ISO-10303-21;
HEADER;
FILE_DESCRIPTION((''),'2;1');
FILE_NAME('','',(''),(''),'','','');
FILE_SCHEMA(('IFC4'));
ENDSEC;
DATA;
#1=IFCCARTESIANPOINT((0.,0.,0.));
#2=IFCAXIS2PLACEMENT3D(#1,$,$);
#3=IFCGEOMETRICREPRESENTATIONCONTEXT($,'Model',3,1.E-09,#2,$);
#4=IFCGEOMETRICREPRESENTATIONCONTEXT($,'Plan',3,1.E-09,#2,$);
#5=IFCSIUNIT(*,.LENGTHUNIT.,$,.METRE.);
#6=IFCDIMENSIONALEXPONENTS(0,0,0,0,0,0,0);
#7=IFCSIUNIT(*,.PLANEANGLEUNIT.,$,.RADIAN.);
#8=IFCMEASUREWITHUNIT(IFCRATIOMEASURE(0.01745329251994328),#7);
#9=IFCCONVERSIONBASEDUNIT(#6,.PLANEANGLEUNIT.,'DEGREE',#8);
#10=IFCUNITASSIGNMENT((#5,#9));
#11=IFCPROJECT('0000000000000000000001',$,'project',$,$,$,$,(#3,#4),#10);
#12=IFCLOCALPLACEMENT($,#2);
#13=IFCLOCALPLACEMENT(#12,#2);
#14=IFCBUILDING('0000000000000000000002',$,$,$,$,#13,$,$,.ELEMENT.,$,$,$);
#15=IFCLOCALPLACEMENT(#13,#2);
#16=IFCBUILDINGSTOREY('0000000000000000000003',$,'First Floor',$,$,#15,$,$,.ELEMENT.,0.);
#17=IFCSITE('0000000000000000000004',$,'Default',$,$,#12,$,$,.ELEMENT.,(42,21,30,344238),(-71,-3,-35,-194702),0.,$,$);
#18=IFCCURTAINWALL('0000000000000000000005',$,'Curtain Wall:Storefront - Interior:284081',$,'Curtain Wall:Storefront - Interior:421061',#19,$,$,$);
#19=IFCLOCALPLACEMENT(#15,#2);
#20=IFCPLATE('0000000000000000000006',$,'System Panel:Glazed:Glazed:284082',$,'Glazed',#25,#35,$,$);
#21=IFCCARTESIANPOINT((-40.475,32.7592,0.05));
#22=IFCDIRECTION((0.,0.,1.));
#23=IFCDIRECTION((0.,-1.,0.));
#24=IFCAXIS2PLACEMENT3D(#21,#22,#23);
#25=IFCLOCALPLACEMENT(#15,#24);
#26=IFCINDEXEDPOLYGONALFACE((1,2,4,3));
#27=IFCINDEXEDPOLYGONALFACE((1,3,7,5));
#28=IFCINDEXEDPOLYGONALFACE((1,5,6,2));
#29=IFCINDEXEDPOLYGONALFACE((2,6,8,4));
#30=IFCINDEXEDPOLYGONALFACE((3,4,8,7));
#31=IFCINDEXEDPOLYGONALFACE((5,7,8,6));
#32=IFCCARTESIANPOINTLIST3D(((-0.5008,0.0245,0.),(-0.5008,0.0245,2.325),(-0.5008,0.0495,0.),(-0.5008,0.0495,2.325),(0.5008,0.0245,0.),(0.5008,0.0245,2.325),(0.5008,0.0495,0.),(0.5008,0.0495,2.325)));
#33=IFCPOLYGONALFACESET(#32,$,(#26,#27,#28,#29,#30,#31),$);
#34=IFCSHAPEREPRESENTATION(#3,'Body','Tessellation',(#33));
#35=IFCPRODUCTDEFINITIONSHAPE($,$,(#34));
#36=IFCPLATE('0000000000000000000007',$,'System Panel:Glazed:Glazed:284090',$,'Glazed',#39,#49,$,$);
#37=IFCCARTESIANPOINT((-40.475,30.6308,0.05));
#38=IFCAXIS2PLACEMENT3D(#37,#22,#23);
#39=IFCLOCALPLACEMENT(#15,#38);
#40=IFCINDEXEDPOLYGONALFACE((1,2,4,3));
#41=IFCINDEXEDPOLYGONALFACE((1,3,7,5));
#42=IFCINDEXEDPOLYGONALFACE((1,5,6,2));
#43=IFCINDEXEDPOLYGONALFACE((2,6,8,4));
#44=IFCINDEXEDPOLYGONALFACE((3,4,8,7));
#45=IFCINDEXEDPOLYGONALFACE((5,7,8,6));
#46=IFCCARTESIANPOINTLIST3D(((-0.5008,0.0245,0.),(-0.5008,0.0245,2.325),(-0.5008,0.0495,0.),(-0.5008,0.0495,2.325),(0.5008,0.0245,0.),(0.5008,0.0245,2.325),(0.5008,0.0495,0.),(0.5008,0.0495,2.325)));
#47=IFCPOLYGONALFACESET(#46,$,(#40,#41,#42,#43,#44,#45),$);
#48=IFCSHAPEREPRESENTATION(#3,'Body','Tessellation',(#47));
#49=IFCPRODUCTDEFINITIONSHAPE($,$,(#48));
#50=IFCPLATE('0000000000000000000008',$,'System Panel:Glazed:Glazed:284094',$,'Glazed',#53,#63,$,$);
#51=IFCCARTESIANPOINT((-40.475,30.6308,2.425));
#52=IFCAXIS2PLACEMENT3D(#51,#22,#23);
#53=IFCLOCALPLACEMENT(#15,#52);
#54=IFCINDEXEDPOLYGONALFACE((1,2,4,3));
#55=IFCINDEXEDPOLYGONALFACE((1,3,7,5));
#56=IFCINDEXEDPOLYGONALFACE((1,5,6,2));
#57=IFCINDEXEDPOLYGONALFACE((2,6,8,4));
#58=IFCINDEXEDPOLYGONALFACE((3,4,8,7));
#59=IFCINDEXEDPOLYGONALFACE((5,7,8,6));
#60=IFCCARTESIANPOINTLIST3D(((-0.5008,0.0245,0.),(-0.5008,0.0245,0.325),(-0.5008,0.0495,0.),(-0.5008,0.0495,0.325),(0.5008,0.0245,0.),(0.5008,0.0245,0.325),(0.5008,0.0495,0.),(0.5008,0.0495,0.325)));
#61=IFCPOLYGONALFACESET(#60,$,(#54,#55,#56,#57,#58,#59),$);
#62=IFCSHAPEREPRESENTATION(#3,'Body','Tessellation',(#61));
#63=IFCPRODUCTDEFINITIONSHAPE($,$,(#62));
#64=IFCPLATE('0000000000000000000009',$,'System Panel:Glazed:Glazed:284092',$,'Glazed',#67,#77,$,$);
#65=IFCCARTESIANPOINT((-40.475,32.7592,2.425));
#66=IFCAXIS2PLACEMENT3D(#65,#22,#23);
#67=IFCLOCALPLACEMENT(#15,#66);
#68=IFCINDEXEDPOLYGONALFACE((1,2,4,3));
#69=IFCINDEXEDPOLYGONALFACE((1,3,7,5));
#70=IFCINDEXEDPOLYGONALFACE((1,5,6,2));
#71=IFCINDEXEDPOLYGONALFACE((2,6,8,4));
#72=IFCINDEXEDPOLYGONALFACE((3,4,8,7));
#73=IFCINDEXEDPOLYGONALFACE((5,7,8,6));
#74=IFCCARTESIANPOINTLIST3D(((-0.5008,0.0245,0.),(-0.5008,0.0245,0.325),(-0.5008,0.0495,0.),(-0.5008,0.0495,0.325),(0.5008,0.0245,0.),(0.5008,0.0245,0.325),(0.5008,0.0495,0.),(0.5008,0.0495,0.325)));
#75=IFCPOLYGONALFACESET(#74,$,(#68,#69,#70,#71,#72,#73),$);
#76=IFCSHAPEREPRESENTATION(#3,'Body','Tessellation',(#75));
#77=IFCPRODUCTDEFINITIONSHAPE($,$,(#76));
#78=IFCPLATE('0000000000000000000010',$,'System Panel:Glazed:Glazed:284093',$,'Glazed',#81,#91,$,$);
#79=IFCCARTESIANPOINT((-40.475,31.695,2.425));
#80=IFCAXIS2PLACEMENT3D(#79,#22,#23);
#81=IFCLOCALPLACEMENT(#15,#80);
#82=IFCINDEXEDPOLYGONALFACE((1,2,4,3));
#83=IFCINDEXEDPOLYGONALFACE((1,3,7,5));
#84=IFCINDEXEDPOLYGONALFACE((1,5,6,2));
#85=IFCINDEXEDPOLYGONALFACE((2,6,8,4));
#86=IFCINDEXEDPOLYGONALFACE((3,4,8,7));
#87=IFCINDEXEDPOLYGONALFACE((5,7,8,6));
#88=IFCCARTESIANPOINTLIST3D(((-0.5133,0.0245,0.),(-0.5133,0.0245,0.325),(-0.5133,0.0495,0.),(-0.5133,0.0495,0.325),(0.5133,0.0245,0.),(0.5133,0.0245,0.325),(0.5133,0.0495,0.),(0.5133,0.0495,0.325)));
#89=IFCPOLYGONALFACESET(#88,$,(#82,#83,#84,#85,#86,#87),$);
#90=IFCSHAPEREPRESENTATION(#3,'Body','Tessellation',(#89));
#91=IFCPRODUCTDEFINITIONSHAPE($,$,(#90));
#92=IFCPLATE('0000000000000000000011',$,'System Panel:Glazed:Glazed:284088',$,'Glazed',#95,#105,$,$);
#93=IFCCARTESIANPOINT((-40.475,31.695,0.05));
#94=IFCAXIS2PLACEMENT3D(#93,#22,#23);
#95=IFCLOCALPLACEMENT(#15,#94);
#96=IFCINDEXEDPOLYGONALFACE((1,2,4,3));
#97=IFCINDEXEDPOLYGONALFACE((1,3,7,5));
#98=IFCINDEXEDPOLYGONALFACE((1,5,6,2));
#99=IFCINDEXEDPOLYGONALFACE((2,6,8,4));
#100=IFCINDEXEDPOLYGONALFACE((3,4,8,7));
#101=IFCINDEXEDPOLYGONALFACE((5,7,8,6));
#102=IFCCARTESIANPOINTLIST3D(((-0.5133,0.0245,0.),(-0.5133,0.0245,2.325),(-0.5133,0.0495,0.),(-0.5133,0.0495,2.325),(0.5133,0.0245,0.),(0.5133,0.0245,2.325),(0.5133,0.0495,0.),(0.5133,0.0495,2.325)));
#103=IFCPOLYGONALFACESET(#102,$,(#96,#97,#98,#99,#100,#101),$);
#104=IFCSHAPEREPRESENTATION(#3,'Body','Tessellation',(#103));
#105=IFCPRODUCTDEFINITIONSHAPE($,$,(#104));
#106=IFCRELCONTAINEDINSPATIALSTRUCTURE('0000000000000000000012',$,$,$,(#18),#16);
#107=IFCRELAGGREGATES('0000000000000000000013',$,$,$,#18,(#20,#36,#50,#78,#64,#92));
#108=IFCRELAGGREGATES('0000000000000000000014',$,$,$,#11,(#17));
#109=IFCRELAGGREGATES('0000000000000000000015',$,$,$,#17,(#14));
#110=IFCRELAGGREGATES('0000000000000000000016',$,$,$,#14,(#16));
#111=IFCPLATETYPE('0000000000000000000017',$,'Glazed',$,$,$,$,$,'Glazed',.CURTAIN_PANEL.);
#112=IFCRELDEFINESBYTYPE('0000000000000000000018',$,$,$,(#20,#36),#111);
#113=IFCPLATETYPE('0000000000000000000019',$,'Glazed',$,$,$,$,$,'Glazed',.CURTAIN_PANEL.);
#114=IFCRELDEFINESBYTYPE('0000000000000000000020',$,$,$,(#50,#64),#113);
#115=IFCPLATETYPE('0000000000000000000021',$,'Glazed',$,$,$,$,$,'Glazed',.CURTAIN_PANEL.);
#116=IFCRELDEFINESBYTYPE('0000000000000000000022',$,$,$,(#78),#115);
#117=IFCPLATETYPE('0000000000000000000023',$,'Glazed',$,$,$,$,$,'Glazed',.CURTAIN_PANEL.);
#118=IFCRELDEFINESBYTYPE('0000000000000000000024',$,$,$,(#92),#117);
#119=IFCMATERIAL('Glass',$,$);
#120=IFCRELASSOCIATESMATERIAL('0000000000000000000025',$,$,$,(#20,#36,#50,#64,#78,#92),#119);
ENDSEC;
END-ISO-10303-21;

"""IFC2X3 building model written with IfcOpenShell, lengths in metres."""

from ifc_helpers import new_model, entity, si_unit, converted_unit, frame, origin, origin_2d_with_axis, place, context, project, spatial, rectangle, extrude, source, transform, mapped, material, type_object, type_shapes, element, aggregate, save


model = new_model("IFC2X3")

# Units and contexts
model_context = context("Model", 3, precision=1e-09, world=origin())
plan_context = context("Plan", 3, precision=1e-09, world=origin())
ifc_project = project(units=[si_unit("LENGTHUNIT", "METRE"), converted_unit("PLANEANGLEUNIT", "DEGREE", entity("IfcRatioMeasure", 0.01745329251994328), si_unit("PLANEANGLEUNIT", "RADIAN"), dimensions=[0, 0, 0, 0, 0, 0, 0])], contexts=[model_context, plan_context])

# Site, building, storey
site_placement = place(None, origin())
site = spatial("IfcSite", under=ifc_project, at=site_placement, Name="Default", CompositionType="ELEMENT", RefLatitude=(42, 21, 30, 344238), RefLongitude=(-71, -3, -35, -194702), RefElevation=0.0)
building_placement = place(site_placement, origin())
building = spatial("IfcBuilding", under=site, at=building_placement, CompositionType="ELEMENT")
storey_placement = place(building_placement, origin())
storey = spatial("IfcBuildingStorey", under=building, at=storey_placement, Name="First Floor", CompositionType="ELEMENT", Elevation=0.0)

# Curtain wall, plates
curtain_wall_placement = place(storey_placement, origin())
curtain_wall = element("IfcCurtainWall", 1, at=curtain_wall_placement, inside=storey, Name="Curtain Wall:Storefront - Interior:284081", ObjectType="Curtain Wall:Storefront - Interior:421061")
ifc_material_1 = material(Name="Glass")
plate_type_1 = type_object("IfcPlateType", Name="Glazed", ElementType="Glazed", PredefinedType="CURTAIN_PANEL")
shared_shape_1 = source(origin(), model_context, "Body", "SweptSolid", [
    extrude(rectangle(XDim=0.025, YDim=1.0017, at=origin_2d_with_axis()), frame((0.0, 0.037, 0.0), z_axis=(0.0, 0.0, 1.0), x_axis=(0.0, 1.0, 0.0)), (0.0, 0.0, 1.0), 2.325),
])
type_shapes(plate_type_1, [shared_shape_1])
plate_1_placement = place(storey_placement, frame((-40.475, 32.7592, 0.05), z_axis=(0.0, 0.0, 1.0), x_axis=(0.0, -1.0, 0.0)))
plate_1 = element("IfcPlate", 2, at=plate_1_placement, type_object=plate_type_1, material=ifc_material_1, Name="System Panel:Glazed:Glazed:284082", ObjectType="Glazed", context=model_context, shape_type="MappedRepresentation", body=[
    mapped(shared_shape_1, transform((0.0, 0.0, 0.0), scale=1.0)),
])
plate_2_placement = place(storey_placement, frame((-40.475, 30.6308, 0.05), z_axis=(0.0, 0.0, 1.0), x_axis=(0.0, -1.0, 0.0)))
plate_2 = element("IfcPlate", 3, at=plate_2_placement, type_object=plate_type_1, material=ifc_material_1, Name="System Panel:Glazed:Glazed:284090", ObjectType="Glazed", context=model_context, shape_type="MappedRepresentation", body=[
    mapped(shared_shape_1, transform((0.0, 0.0, 0.0), scale=1.0)),
])
plate_type_2 = type_object("IfcPlateType", Name="Glazed", ElementType="Glazed", PredefinedType="CURTAIN_PANEL")
shared_shape_2 = source(origin(), model_context, "Body", "SweptSolid", [
    extrude(rectangle(XDim=0.025, YDim=1.0017, at=origin_2d_with_axis()), frame((0.0, 0.037, 0.0), z_axis=(0.0, 0.0, 1.0), x_axis=(0.0, 1.0, 0.0)), (0.0, 0.0, 1.0), 0.325),
])
type_shapes(plate_type_2, [shared_shape_2])
plate_3_placement = place(storey_placement, frame((-40.475, 30.6308, 2.425), z_axis=(0.0, 0.0, 1.0), x_axis=(0.0, -1.0, 0.0)))
plate_3 = element("IfcPlate", 4, at=plate_3_placement, type_object=plate_type_2, material=ifc_material_1, Name="System Panel:Glazed:Glazed:284094", ObjectType="Glazed", context=model_context, shape_type="MappedRepresentation", body=[
    mapped(shared_shape_2, transform((0.0, 0.0, 0.0), scale=1.0)),
])
plate_4_placement = place(storey_placement, frame((-40.475, 32.7592, 2.425), z_axis=(0.0, 0.0, 1.0), x_axis=(0.0, -1.0, 0.0)))
plate_4 = element("IfcPlate", 5, at=plate_4_placement, type_object=plate_type_2, material=ifc_material_1, Name="System Panel:Glazed:Glazed:284092", ObjectType="Glazed", context=model_context, shape_type="MappedRepresentation", body=[
    mapped(shared_shape_2, transform((0.0, 0.0, 0.0), scale=1.0)),
])
plate_type_3 = type_object("IfcPlateType", Name="Glazed", ElementType="Glazed", PredefinedType="CURTAIN_PANEL")
shared_shape_3 = source(origin(), model_context, "Body", "SweptSolid", [
    extrude(rectangle(XDim=0.025, YDim=1.0267, at=origin_2d_with_axis()), frame((0.0, 0.037, 0.0), z_axis=(0.0, 0.0, 1.0), x_axis=(0.0, 1.0, 0.0)), (0.0, 0.0, 1.0), 0.325),
])
type_shapes(plate_type_3, [shared_shape_3])
plate_5_placement = place(storey_placement, frame((-40.475, 31.695, 2.425), z_axis=(0.0, 0.0, 1.0), x_axis=(0.0, -1.0, 0.0)))
plate_5 = element("IfcPlate", 6, at=plate_5_placement, type_object=plate_type_3, material=ifc_material_1, Name="System Panel:Glazed:Glazed:284093", ObjectType="Glazed", context=model_context, shape_type="MappedRepresentation", body=[
    mapped(shared_shape_3, transform((0.0, 0.0, 0.0), scale=1.0)),
])
plate_type_4 = type_object("IfcPlateType", Name="Glazed", ElementType="Glazed", PredefinedType="CURTAIN_PANEL")
shared_shape_4 = source(origin(), model_context, "Body", "SweptSolid", [
    extrude(rectangle(XDim=0.025, YDim=1.0267, at=origin_2d_with_axis()), frame((0.0, 0.037, 0.0), z_axis=(0.0, 0.0, 1.0), x_axis=(0.0, 1.0, 0.0)), (0.0, 0.0, 1.0), 2.325),
])
type_shapes(plate_type_4, [shared_shape_4])
plate_6_placement = place(storey_placement, frame((-40.475, 31.695, 0.05), z_axis=(0.0, 0.0, 1.0), x_axis=(0.0, -1.0, 0.0)))
plate_6 = element("IfcPlate", 7, at=plate_6_placement, type_object=plate_type_4, material=ifc_material_1, Name="System Panel:Glazed:Glazed:284088", ObjectType="Glazed", context=model_context, shape_type="MappedRepresentation", body=[
    mapped(shared_shape_4, transform((0.0, 0.0, 0.0), scale=1.0)),
])
aggregate(curtain_wall, [plate_1, plate_2, plate_3, plate_5, plate_4, plate_6])

save(model, "model.ifc")
